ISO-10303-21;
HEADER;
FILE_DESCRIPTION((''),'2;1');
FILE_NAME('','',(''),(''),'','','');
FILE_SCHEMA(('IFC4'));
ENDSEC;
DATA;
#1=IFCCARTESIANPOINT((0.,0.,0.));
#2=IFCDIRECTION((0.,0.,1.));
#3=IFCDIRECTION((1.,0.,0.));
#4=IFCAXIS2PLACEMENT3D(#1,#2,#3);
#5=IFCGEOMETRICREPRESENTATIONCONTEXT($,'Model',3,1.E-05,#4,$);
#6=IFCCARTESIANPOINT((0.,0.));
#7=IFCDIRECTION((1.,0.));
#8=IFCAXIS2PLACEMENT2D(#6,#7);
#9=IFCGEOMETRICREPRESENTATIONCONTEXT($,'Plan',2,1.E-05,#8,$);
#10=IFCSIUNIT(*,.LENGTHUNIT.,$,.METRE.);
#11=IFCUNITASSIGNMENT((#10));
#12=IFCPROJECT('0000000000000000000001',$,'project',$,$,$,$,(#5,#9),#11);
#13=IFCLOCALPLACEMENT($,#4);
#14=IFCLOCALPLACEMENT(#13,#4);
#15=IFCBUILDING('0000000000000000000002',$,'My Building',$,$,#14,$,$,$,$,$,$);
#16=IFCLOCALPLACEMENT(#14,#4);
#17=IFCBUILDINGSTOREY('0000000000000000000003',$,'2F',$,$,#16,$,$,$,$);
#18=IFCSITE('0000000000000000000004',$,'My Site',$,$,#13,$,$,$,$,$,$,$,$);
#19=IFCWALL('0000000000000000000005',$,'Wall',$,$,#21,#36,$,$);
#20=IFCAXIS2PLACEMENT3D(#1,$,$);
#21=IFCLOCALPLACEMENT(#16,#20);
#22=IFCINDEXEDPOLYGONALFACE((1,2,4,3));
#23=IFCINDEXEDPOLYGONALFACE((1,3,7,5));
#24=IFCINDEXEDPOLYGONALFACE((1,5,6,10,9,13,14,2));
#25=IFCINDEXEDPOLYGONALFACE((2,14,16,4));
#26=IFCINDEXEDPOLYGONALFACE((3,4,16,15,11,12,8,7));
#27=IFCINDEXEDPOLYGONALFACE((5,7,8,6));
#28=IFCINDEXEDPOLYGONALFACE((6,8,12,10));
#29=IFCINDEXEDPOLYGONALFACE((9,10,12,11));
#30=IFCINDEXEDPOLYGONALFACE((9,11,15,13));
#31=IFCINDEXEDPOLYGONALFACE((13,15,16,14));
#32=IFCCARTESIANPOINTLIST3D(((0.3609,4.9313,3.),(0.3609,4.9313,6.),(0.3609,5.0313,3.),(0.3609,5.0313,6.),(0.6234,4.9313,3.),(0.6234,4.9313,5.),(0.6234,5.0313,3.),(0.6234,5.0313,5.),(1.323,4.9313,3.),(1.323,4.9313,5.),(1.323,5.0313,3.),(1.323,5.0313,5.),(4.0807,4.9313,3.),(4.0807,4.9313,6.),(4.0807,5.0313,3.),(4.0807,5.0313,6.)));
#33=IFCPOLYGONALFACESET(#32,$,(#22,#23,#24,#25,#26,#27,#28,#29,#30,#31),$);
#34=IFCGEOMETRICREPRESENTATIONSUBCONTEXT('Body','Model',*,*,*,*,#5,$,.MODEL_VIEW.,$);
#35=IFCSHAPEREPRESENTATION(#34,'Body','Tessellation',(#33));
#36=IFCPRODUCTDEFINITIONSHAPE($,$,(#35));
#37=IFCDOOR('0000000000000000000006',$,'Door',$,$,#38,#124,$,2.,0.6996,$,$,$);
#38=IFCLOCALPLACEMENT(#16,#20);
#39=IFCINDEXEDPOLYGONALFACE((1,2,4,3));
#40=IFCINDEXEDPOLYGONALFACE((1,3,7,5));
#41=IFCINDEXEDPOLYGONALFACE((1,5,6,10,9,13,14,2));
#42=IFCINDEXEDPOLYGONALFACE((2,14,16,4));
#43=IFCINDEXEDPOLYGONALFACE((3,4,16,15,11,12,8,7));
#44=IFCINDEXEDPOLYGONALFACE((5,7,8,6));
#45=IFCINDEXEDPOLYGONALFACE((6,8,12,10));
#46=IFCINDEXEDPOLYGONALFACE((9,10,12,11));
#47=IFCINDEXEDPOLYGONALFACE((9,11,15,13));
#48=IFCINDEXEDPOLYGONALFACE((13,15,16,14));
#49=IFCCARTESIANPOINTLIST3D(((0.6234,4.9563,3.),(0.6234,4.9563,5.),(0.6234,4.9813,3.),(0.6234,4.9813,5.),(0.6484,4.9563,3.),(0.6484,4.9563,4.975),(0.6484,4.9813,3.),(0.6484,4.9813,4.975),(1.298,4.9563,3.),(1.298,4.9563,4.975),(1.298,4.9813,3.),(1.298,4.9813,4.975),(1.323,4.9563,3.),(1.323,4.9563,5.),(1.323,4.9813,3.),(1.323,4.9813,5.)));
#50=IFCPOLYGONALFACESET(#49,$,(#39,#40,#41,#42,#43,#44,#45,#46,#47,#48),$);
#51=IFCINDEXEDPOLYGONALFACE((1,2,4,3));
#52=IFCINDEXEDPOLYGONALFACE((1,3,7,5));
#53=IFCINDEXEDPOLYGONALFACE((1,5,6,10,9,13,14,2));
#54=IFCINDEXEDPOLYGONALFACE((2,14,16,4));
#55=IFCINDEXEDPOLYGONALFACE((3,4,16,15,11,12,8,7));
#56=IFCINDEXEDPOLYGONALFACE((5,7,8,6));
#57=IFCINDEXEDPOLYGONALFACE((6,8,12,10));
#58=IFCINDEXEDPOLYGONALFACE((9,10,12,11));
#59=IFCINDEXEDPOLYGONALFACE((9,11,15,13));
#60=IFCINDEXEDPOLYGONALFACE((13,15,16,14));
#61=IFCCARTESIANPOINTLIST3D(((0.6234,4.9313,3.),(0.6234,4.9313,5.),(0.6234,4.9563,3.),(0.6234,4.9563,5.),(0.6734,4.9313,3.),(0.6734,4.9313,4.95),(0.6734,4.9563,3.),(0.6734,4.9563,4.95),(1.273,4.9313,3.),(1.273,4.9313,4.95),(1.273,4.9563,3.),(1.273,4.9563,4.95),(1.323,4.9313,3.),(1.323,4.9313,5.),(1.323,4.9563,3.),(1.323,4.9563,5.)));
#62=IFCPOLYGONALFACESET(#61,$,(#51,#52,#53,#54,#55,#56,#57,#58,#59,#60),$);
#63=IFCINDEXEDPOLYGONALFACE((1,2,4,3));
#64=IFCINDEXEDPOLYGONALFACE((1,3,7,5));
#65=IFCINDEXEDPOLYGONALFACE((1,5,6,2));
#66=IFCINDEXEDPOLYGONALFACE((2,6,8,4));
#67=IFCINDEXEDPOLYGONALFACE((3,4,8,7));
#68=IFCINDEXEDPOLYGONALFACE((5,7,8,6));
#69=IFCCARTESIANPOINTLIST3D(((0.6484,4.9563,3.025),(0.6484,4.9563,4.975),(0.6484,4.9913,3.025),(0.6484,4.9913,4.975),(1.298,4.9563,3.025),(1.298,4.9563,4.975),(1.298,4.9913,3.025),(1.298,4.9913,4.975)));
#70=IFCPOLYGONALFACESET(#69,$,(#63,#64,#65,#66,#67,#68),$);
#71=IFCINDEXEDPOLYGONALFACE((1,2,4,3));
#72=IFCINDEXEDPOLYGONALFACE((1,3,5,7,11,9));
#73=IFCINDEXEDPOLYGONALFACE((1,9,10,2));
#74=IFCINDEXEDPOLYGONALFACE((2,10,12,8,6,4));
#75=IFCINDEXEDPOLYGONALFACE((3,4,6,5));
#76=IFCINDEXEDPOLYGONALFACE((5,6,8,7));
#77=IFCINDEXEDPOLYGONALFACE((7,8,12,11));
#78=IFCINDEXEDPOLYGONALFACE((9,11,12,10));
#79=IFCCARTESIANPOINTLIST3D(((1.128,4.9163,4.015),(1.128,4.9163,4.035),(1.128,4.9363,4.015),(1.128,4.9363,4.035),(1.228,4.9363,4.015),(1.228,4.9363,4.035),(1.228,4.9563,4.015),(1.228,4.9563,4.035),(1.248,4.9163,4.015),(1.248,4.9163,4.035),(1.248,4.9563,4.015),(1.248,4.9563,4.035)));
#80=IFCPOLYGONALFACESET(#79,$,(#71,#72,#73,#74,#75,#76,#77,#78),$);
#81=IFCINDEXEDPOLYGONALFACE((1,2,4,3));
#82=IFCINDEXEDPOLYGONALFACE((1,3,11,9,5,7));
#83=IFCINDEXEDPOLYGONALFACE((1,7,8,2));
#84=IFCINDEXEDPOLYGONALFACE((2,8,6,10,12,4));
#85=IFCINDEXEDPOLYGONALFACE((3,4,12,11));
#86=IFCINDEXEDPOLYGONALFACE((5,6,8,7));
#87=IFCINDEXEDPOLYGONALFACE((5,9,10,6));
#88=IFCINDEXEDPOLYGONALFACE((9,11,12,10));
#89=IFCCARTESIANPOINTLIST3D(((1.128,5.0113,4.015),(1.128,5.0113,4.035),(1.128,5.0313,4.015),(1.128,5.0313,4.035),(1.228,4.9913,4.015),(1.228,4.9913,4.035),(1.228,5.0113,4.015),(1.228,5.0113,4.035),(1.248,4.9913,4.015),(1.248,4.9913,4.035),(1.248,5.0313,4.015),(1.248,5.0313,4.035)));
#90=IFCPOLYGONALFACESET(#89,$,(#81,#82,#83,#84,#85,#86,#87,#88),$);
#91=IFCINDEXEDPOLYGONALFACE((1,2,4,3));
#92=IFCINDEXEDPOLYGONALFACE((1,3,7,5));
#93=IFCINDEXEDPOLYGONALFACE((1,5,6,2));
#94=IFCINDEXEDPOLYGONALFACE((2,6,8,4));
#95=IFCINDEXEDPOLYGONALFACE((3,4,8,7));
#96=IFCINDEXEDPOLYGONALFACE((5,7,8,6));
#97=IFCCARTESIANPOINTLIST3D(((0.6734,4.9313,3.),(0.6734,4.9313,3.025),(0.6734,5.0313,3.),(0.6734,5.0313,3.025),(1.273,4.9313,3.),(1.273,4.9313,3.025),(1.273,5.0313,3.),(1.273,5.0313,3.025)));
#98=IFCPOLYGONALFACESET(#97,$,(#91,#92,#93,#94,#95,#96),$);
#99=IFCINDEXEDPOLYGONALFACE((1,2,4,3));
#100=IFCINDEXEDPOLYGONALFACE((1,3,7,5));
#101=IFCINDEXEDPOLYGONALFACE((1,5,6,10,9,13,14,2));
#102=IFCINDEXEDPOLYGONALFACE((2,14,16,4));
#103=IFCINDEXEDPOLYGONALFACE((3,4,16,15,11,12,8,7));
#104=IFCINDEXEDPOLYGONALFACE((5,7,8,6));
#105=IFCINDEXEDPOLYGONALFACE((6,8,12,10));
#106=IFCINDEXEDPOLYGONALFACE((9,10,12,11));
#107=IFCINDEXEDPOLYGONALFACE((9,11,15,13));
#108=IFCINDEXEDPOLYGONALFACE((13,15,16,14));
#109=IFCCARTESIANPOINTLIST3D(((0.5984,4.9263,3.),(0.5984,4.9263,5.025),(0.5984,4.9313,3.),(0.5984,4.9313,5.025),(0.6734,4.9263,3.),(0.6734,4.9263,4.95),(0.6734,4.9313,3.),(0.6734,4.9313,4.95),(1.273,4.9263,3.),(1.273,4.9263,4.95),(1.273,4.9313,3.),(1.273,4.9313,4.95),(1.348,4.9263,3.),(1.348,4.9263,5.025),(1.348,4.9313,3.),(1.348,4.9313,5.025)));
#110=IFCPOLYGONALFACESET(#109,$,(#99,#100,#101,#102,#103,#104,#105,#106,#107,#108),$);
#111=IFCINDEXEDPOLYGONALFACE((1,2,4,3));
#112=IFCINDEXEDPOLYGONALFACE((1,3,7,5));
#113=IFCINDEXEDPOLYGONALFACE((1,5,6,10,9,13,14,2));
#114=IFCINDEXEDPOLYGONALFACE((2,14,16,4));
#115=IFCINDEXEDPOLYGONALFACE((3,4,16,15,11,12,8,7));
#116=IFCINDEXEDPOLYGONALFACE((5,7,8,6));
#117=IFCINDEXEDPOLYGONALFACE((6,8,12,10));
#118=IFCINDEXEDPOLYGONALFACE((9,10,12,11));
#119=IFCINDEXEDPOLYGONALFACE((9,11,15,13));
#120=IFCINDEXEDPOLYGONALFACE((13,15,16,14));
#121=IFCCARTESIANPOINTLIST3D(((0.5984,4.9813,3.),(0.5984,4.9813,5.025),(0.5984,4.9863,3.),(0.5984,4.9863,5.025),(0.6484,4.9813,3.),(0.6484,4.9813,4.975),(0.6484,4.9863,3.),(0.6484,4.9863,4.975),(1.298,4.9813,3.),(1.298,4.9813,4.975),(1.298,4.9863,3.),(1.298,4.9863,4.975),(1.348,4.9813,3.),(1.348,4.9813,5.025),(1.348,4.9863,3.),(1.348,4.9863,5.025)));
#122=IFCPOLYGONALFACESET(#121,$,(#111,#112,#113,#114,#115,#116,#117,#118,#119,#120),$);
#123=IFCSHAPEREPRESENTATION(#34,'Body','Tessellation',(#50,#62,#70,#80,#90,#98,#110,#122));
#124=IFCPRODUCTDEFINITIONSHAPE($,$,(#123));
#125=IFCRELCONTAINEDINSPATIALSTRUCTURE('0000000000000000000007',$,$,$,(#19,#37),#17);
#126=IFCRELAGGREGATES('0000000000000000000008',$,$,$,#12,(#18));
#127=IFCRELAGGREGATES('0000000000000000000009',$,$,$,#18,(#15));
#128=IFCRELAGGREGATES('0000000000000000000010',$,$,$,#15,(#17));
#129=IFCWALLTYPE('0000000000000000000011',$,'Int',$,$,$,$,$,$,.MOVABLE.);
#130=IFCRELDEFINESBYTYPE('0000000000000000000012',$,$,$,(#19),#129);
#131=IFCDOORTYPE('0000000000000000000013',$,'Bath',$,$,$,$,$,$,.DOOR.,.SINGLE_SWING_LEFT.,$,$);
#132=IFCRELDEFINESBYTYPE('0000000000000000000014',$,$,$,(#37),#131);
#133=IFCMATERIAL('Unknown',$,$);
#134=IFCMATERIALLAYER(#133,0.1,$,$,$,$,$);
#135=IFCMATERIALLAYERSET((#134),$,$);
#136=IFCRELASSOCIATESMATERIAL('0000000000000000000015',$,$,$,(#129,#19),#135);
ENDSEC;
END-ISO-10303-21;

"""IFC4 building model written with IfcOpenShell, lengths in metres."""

from ifc_helpers import new_model, entity, si_unit, frame, origin_with_axes, origin_2d_with_axis, place, context, subcontext, project, spatial, line, indexed_curve, outline, extrude, shape, source, transform, mapped, material, layer, layer_set, layer_usage, type_object, type_shapes, element, fill, save


model = new_model("IFC4")

# Units and contexts
model_context = context("Model", 3, precision=1e-05, world=origin_with_axes())
plan_context = context("Plan", 2, precision=1e-05, world=origin_2d_with_axis())
body_context_1 = subcontext(model_context, "Body", "Model", "MODEL_VIEW")
body_context_2 = subcontext(plan_context, "Body", "Plan", "PLAN_VIEW")
ifc_project = project(units=[si_unit("LENGTHUNIT", "METRE")], contexts=[model_context, plan_context])

# Site, building, storey
site_placement = place(None, origin_with_axes())
site = spatial("IfcSite", under=ifc_project, at=site_placement, Name="My Site")
building_placement = place(site_placement, origin_with_axes())
building = spatial("IfcBuilding", under=site, at=building_placement, Name="My Building")
storey_placement = place(building_placement, origin_with_axes())
storey = spatial("IfcBuildingStorey", under=building, at=storey_placement, Name="2F")

# Shared definitions
ifc_material = material(Name="Unknown")

# Shared definitions
ifc_layer_1 = layer(ifc_material, 0.1)
ifc_layer_set_1 = layer_set([ifc_layer_1])
wall_type_1 = type_object("IfcWallType", Name="Int", PredefinedType="MOVABLE", material=ifc_layer_set_1)

# Wall, opening, door
ifc_layer_usage_1 = layer_usage(ifc_layer_set_1, "AXIS2", "POSITIVE", 0.0)
wall_1_placement = place(storey_placement, frame((4.0807, 5.0313, 3.0), z_axis=(0.0, 0.0, 1.0), x_axis=(-1.0, 0.0, 0.0)))
wall_1 = element("IfcWall", 1, at=wall_1_placement, inside=storey, type_object=wall_type_1, material=ifc_layer_usage_1, Name="Wall", context=body_context_1, shape_type="SweptSolid", body=[
    extrude(outline(indexed_curve([(0.0, 0.0), (0.0, 0.1), (3.7198, 0.1), (3.7198, 0.0)], segments=[line(1, 2, 3, 4, 1)])), origin_with_axes(), (0.0, 0.0, 1.0), 3.0),
])
shared_shape_1 = source(origin_with_axes(), body_context_1, "Body", "SweptSolid", [
    extrude(outline(indexed_curve([(0.0, 0.0), (0.6996, 0.0), (0.6996, 2.0), (0.0, 2.0)], segments=[line(1, 2, 3, 4, 1)])), frame((0.0, -0.6, 0.0), z_axis=(0.0, -1.0, 0.0), x_axis=(1.0, 0.0, 0.0)), (0.0, 0.0, -1.0), 1.2),
])
opening_1_placement = place(wall_1_placement, frame((3.4573, 0.1, 0.0), z_axis=(0.0, 0.0, 1.0), x_axis=(-1.0, 0.0, 0.0)))
opening_1 = element("IfcOpeningElement", 2, at=opening_1_placement, cuts=wall_1, PredefinedType="OPENING", context=body_context_1, shape_type="MappedRepresentation", body=[
    mapped(shared_shape_1, transform((0.0, 0.0, 0.0), x_axis=(1.0, 0.0, 0.0), y_axis=(0.0, 1.0, 0.0), z_axis=(0.0, 0.0, 1.0), scale=1.0)),
])
door_type_1 = type_object("IfcDoorType", Name="Bath", OperationType="SINGLE_SWING_LEFT", PredefinedType="DOOR")
shared_shape_2 = source(origin_with_axes(), body_context_1, "Body", "SweptSolid", [
    extrude(outline(indexed_curve([(0.0, 0.0), (0.0, 2.0), (0.6996, 2.0), (0.6996, 0.0), (0.6746, 0.0), (0.6746, 1.975), (0.025, 1.975), (0.025, 0.0)], segments=[line(1, 2, 3, 4, 5, 6, 7, 8, 1)])), frame((0.0, 0.025, 0.0), z_axis=(0.0, -1.0, 0.0), x_axis=(1.0, 0.0, 0.0)), (0.0, 0.0, -1.0), 0.025),
    extrude(outline(indexed_curve([(0.0, 0.0), (0.0, 2.0), (0.6996, 2.0), (0.6996, 0.0), (0.6496, 0.0), (0.6496, 1.95), (0.05, 1.95), (0.05, 0.0)], segments=[line(1, 2, 3, 4, 5, 6, 7, 8, 1)])), frame((0.0, 0.0, 0.0), z_axis=(0.0, -1.0, 0.0), x_axis=(1.0, 0.0, 0.0)), (0.0, 0.0, -1.0), 0.025),
    extrude(outline(indexed_curve([(0.0, 0.0), (0.6496, 0.0), (0.6496, 0.035), (0.0, 0.035)], segments=[line(1, 2, 3, 4, 1)])), frame((0.025, 0.025, 0.025), z_axis=(0.0, 0.0, 1.0), x_axis=(1.0, 0.0, 0.0)), (0.0, 0.0, 1.0), 1.95),
    extrude(outline(indexed_curve([(0.0, 0.0), (0.0, -0.04), (-0.12, -0.04), (-0.12, -0.02), (-0.02, -0.02), (-0.02, 0.0)], segments=[line(1, 2, 3, 4, 5, 6, 1)])), frame((0.6246, 0.025, 1.015), z_axis=(0.0, 0.0, 1.0), x_axis=(1.0, 0.0, 0.0)), (0.0, 0.0, 1.0), 0.02),
    extrude(outline(indexed_curve([(0.0, 0.0), (0.0, 0.04), (-0.12, 0.04), (-0.12, 0.02), (-0.02, 0.02), (-0.02, 0.0)], segments=[line(1, 2, 3, 4, 5, 6, 1)])), frame((0.6246, 0.06, 1.015), z_axis=(0.0, 0.0, 1.0), x_axis=(1.0, 0.0, 0.0)), (0.0, 0.0, 1.0), 0.02),
    extrude(outline(indexed_curve([(0.0, 0.0), (0.5996, 0.0), (0.5996, 0.1), (0.0, 0.1)], segments=[line(1, 2, 3, 4, 1)])), frame((0.05, 0.0, 0.0), z_axis=(0.0, 0.0, 1.0), x_axis=(1.0, 0.0, 0.0)), (0.0, 0.0, 1.0), 0.025),
    extrude(outline(indexed_curve([(0.0, 0.0), (0.0, 2.025), (0.7496, 2.025), (0.7496, 0.0), (0.6746, 0.0), (0.6746, 1.95), (0.075, 1.95), (0.075, 0.0)], segments=[line(1, 2, 3, 4, 5, 6, 7, 8, 1)])), frame((-0.025, -0.005, 0.0), z_axis=(0.0, -1.0, 0.0), x_axis=(1.0, 0.0, 0.0)), (0.0, 0.0, -1.0), 0.005),
    extrude(outline(indexed_curve([(0.0, 0.0), (0.0, 2.025), (0.7496, 2.025), (0.7496, 0.0), (0.6996, 0.0), (0.6996, 1.975), (0.05, 1.975), (0.05, 0.0)], segments=[line(1, 2, 3, 4, 5, 6, 7, 8, 1)])), frame((-0.025, 0.05, 0.0), z_axis=(0.0, -1.0, 0.0), x_axis=(1.0, 0.0, 0.0)), (0.0, 0.0, -1.0), 0.005),
])
shared_shape_3 = source(origin_with_axes(), body_context_2, "Body", "Curve2D", [
    entity("IfcIndexedPolyCurve", entity("IfcCartesianPointList2D", [[0.0, 0.0], [0.0, 0.05], [0.025, 0.05], [0.025, 0.025], [0.05, 0.025], [0.05, 0.0]]), [entity("IfcLineIndex", [1, 2, 3, 4, 5, 6, 1])]),
    entity("IfcIndexedPolyCurve", entity("IfcCartesianPointList2D", [[0.6996, 0.0], [0.6996, 0.05], [0.6746, 0.05], [0.6746, 0.025], [0.6496, 0.025], [0.6496, 0.0]]), [entity("IfcLineIndex", [1, 2, 3, 4, 5, 6, 1])]),
    entity("IfcTrimmedCurve", entity("IfcEllipse", entity("IfcAxis2Placement2D", entity("IfcCartesianPoint", [0.06, 0.05]), entity("IfcDirection", [1.0, 0.0])), 0.6146, 0.6496), [entity("IfcCartesianPoint", [0.6746, 0.05])], [entity("IfcCartesianPoint", [0.06, 0.6996])], True, "CARTESIAN"),
    entity("IfcIndexedPolyCurve", entity("IfcCartesianPointList2D", [[0.025, 0.05], [0.06, 0.05], [0.06, 0.6996], [0.025, 0.6996]]), [entity("IfcLineIndex", [1, 2, 3, 4, 1])]),
])
type_shapes(door_type_1, [shared_shape_2, shared_shape_3])
door_1_placement = place(opening_1_placement, frame((0.0, 0.0, 0.0), z_axis=(0.0, 0.0, 1.0), x_axis=(1.0, 0.0, 0.0)))
door_1 = element("IfcDoor", 3, at=door_1_placement, inside=storey, type_object=door_type_1, Name="Door", OverallHeight=2.0, OverallWidth=0.6996, shapes=[
    shape(body_context_1, "Body", "MappedRepresentation", [mapped(shared_shape_2, transform((0.0, 0.0, 0.0), x_axis=(1.0, 0.0, 0.0), y_axis=(0.0, 1.0, 0.0), z_axis=(0.0, 0.0, 1.0), scale=1.0))]),
    shape(body_context_2, "Body", "MappedRepresentation", [mapped(shared_shape_3, transform((0.0, 0.0, 0.0), x_axis=(1.0, 0.0, 0.0), y_axis=(0.0, 1.0, 0.0), z_axis=(0.0, 0.0, 1.0), scale=1.0))]),
])
fill(opening_1, door_1)

save(model, "model.ifc")
